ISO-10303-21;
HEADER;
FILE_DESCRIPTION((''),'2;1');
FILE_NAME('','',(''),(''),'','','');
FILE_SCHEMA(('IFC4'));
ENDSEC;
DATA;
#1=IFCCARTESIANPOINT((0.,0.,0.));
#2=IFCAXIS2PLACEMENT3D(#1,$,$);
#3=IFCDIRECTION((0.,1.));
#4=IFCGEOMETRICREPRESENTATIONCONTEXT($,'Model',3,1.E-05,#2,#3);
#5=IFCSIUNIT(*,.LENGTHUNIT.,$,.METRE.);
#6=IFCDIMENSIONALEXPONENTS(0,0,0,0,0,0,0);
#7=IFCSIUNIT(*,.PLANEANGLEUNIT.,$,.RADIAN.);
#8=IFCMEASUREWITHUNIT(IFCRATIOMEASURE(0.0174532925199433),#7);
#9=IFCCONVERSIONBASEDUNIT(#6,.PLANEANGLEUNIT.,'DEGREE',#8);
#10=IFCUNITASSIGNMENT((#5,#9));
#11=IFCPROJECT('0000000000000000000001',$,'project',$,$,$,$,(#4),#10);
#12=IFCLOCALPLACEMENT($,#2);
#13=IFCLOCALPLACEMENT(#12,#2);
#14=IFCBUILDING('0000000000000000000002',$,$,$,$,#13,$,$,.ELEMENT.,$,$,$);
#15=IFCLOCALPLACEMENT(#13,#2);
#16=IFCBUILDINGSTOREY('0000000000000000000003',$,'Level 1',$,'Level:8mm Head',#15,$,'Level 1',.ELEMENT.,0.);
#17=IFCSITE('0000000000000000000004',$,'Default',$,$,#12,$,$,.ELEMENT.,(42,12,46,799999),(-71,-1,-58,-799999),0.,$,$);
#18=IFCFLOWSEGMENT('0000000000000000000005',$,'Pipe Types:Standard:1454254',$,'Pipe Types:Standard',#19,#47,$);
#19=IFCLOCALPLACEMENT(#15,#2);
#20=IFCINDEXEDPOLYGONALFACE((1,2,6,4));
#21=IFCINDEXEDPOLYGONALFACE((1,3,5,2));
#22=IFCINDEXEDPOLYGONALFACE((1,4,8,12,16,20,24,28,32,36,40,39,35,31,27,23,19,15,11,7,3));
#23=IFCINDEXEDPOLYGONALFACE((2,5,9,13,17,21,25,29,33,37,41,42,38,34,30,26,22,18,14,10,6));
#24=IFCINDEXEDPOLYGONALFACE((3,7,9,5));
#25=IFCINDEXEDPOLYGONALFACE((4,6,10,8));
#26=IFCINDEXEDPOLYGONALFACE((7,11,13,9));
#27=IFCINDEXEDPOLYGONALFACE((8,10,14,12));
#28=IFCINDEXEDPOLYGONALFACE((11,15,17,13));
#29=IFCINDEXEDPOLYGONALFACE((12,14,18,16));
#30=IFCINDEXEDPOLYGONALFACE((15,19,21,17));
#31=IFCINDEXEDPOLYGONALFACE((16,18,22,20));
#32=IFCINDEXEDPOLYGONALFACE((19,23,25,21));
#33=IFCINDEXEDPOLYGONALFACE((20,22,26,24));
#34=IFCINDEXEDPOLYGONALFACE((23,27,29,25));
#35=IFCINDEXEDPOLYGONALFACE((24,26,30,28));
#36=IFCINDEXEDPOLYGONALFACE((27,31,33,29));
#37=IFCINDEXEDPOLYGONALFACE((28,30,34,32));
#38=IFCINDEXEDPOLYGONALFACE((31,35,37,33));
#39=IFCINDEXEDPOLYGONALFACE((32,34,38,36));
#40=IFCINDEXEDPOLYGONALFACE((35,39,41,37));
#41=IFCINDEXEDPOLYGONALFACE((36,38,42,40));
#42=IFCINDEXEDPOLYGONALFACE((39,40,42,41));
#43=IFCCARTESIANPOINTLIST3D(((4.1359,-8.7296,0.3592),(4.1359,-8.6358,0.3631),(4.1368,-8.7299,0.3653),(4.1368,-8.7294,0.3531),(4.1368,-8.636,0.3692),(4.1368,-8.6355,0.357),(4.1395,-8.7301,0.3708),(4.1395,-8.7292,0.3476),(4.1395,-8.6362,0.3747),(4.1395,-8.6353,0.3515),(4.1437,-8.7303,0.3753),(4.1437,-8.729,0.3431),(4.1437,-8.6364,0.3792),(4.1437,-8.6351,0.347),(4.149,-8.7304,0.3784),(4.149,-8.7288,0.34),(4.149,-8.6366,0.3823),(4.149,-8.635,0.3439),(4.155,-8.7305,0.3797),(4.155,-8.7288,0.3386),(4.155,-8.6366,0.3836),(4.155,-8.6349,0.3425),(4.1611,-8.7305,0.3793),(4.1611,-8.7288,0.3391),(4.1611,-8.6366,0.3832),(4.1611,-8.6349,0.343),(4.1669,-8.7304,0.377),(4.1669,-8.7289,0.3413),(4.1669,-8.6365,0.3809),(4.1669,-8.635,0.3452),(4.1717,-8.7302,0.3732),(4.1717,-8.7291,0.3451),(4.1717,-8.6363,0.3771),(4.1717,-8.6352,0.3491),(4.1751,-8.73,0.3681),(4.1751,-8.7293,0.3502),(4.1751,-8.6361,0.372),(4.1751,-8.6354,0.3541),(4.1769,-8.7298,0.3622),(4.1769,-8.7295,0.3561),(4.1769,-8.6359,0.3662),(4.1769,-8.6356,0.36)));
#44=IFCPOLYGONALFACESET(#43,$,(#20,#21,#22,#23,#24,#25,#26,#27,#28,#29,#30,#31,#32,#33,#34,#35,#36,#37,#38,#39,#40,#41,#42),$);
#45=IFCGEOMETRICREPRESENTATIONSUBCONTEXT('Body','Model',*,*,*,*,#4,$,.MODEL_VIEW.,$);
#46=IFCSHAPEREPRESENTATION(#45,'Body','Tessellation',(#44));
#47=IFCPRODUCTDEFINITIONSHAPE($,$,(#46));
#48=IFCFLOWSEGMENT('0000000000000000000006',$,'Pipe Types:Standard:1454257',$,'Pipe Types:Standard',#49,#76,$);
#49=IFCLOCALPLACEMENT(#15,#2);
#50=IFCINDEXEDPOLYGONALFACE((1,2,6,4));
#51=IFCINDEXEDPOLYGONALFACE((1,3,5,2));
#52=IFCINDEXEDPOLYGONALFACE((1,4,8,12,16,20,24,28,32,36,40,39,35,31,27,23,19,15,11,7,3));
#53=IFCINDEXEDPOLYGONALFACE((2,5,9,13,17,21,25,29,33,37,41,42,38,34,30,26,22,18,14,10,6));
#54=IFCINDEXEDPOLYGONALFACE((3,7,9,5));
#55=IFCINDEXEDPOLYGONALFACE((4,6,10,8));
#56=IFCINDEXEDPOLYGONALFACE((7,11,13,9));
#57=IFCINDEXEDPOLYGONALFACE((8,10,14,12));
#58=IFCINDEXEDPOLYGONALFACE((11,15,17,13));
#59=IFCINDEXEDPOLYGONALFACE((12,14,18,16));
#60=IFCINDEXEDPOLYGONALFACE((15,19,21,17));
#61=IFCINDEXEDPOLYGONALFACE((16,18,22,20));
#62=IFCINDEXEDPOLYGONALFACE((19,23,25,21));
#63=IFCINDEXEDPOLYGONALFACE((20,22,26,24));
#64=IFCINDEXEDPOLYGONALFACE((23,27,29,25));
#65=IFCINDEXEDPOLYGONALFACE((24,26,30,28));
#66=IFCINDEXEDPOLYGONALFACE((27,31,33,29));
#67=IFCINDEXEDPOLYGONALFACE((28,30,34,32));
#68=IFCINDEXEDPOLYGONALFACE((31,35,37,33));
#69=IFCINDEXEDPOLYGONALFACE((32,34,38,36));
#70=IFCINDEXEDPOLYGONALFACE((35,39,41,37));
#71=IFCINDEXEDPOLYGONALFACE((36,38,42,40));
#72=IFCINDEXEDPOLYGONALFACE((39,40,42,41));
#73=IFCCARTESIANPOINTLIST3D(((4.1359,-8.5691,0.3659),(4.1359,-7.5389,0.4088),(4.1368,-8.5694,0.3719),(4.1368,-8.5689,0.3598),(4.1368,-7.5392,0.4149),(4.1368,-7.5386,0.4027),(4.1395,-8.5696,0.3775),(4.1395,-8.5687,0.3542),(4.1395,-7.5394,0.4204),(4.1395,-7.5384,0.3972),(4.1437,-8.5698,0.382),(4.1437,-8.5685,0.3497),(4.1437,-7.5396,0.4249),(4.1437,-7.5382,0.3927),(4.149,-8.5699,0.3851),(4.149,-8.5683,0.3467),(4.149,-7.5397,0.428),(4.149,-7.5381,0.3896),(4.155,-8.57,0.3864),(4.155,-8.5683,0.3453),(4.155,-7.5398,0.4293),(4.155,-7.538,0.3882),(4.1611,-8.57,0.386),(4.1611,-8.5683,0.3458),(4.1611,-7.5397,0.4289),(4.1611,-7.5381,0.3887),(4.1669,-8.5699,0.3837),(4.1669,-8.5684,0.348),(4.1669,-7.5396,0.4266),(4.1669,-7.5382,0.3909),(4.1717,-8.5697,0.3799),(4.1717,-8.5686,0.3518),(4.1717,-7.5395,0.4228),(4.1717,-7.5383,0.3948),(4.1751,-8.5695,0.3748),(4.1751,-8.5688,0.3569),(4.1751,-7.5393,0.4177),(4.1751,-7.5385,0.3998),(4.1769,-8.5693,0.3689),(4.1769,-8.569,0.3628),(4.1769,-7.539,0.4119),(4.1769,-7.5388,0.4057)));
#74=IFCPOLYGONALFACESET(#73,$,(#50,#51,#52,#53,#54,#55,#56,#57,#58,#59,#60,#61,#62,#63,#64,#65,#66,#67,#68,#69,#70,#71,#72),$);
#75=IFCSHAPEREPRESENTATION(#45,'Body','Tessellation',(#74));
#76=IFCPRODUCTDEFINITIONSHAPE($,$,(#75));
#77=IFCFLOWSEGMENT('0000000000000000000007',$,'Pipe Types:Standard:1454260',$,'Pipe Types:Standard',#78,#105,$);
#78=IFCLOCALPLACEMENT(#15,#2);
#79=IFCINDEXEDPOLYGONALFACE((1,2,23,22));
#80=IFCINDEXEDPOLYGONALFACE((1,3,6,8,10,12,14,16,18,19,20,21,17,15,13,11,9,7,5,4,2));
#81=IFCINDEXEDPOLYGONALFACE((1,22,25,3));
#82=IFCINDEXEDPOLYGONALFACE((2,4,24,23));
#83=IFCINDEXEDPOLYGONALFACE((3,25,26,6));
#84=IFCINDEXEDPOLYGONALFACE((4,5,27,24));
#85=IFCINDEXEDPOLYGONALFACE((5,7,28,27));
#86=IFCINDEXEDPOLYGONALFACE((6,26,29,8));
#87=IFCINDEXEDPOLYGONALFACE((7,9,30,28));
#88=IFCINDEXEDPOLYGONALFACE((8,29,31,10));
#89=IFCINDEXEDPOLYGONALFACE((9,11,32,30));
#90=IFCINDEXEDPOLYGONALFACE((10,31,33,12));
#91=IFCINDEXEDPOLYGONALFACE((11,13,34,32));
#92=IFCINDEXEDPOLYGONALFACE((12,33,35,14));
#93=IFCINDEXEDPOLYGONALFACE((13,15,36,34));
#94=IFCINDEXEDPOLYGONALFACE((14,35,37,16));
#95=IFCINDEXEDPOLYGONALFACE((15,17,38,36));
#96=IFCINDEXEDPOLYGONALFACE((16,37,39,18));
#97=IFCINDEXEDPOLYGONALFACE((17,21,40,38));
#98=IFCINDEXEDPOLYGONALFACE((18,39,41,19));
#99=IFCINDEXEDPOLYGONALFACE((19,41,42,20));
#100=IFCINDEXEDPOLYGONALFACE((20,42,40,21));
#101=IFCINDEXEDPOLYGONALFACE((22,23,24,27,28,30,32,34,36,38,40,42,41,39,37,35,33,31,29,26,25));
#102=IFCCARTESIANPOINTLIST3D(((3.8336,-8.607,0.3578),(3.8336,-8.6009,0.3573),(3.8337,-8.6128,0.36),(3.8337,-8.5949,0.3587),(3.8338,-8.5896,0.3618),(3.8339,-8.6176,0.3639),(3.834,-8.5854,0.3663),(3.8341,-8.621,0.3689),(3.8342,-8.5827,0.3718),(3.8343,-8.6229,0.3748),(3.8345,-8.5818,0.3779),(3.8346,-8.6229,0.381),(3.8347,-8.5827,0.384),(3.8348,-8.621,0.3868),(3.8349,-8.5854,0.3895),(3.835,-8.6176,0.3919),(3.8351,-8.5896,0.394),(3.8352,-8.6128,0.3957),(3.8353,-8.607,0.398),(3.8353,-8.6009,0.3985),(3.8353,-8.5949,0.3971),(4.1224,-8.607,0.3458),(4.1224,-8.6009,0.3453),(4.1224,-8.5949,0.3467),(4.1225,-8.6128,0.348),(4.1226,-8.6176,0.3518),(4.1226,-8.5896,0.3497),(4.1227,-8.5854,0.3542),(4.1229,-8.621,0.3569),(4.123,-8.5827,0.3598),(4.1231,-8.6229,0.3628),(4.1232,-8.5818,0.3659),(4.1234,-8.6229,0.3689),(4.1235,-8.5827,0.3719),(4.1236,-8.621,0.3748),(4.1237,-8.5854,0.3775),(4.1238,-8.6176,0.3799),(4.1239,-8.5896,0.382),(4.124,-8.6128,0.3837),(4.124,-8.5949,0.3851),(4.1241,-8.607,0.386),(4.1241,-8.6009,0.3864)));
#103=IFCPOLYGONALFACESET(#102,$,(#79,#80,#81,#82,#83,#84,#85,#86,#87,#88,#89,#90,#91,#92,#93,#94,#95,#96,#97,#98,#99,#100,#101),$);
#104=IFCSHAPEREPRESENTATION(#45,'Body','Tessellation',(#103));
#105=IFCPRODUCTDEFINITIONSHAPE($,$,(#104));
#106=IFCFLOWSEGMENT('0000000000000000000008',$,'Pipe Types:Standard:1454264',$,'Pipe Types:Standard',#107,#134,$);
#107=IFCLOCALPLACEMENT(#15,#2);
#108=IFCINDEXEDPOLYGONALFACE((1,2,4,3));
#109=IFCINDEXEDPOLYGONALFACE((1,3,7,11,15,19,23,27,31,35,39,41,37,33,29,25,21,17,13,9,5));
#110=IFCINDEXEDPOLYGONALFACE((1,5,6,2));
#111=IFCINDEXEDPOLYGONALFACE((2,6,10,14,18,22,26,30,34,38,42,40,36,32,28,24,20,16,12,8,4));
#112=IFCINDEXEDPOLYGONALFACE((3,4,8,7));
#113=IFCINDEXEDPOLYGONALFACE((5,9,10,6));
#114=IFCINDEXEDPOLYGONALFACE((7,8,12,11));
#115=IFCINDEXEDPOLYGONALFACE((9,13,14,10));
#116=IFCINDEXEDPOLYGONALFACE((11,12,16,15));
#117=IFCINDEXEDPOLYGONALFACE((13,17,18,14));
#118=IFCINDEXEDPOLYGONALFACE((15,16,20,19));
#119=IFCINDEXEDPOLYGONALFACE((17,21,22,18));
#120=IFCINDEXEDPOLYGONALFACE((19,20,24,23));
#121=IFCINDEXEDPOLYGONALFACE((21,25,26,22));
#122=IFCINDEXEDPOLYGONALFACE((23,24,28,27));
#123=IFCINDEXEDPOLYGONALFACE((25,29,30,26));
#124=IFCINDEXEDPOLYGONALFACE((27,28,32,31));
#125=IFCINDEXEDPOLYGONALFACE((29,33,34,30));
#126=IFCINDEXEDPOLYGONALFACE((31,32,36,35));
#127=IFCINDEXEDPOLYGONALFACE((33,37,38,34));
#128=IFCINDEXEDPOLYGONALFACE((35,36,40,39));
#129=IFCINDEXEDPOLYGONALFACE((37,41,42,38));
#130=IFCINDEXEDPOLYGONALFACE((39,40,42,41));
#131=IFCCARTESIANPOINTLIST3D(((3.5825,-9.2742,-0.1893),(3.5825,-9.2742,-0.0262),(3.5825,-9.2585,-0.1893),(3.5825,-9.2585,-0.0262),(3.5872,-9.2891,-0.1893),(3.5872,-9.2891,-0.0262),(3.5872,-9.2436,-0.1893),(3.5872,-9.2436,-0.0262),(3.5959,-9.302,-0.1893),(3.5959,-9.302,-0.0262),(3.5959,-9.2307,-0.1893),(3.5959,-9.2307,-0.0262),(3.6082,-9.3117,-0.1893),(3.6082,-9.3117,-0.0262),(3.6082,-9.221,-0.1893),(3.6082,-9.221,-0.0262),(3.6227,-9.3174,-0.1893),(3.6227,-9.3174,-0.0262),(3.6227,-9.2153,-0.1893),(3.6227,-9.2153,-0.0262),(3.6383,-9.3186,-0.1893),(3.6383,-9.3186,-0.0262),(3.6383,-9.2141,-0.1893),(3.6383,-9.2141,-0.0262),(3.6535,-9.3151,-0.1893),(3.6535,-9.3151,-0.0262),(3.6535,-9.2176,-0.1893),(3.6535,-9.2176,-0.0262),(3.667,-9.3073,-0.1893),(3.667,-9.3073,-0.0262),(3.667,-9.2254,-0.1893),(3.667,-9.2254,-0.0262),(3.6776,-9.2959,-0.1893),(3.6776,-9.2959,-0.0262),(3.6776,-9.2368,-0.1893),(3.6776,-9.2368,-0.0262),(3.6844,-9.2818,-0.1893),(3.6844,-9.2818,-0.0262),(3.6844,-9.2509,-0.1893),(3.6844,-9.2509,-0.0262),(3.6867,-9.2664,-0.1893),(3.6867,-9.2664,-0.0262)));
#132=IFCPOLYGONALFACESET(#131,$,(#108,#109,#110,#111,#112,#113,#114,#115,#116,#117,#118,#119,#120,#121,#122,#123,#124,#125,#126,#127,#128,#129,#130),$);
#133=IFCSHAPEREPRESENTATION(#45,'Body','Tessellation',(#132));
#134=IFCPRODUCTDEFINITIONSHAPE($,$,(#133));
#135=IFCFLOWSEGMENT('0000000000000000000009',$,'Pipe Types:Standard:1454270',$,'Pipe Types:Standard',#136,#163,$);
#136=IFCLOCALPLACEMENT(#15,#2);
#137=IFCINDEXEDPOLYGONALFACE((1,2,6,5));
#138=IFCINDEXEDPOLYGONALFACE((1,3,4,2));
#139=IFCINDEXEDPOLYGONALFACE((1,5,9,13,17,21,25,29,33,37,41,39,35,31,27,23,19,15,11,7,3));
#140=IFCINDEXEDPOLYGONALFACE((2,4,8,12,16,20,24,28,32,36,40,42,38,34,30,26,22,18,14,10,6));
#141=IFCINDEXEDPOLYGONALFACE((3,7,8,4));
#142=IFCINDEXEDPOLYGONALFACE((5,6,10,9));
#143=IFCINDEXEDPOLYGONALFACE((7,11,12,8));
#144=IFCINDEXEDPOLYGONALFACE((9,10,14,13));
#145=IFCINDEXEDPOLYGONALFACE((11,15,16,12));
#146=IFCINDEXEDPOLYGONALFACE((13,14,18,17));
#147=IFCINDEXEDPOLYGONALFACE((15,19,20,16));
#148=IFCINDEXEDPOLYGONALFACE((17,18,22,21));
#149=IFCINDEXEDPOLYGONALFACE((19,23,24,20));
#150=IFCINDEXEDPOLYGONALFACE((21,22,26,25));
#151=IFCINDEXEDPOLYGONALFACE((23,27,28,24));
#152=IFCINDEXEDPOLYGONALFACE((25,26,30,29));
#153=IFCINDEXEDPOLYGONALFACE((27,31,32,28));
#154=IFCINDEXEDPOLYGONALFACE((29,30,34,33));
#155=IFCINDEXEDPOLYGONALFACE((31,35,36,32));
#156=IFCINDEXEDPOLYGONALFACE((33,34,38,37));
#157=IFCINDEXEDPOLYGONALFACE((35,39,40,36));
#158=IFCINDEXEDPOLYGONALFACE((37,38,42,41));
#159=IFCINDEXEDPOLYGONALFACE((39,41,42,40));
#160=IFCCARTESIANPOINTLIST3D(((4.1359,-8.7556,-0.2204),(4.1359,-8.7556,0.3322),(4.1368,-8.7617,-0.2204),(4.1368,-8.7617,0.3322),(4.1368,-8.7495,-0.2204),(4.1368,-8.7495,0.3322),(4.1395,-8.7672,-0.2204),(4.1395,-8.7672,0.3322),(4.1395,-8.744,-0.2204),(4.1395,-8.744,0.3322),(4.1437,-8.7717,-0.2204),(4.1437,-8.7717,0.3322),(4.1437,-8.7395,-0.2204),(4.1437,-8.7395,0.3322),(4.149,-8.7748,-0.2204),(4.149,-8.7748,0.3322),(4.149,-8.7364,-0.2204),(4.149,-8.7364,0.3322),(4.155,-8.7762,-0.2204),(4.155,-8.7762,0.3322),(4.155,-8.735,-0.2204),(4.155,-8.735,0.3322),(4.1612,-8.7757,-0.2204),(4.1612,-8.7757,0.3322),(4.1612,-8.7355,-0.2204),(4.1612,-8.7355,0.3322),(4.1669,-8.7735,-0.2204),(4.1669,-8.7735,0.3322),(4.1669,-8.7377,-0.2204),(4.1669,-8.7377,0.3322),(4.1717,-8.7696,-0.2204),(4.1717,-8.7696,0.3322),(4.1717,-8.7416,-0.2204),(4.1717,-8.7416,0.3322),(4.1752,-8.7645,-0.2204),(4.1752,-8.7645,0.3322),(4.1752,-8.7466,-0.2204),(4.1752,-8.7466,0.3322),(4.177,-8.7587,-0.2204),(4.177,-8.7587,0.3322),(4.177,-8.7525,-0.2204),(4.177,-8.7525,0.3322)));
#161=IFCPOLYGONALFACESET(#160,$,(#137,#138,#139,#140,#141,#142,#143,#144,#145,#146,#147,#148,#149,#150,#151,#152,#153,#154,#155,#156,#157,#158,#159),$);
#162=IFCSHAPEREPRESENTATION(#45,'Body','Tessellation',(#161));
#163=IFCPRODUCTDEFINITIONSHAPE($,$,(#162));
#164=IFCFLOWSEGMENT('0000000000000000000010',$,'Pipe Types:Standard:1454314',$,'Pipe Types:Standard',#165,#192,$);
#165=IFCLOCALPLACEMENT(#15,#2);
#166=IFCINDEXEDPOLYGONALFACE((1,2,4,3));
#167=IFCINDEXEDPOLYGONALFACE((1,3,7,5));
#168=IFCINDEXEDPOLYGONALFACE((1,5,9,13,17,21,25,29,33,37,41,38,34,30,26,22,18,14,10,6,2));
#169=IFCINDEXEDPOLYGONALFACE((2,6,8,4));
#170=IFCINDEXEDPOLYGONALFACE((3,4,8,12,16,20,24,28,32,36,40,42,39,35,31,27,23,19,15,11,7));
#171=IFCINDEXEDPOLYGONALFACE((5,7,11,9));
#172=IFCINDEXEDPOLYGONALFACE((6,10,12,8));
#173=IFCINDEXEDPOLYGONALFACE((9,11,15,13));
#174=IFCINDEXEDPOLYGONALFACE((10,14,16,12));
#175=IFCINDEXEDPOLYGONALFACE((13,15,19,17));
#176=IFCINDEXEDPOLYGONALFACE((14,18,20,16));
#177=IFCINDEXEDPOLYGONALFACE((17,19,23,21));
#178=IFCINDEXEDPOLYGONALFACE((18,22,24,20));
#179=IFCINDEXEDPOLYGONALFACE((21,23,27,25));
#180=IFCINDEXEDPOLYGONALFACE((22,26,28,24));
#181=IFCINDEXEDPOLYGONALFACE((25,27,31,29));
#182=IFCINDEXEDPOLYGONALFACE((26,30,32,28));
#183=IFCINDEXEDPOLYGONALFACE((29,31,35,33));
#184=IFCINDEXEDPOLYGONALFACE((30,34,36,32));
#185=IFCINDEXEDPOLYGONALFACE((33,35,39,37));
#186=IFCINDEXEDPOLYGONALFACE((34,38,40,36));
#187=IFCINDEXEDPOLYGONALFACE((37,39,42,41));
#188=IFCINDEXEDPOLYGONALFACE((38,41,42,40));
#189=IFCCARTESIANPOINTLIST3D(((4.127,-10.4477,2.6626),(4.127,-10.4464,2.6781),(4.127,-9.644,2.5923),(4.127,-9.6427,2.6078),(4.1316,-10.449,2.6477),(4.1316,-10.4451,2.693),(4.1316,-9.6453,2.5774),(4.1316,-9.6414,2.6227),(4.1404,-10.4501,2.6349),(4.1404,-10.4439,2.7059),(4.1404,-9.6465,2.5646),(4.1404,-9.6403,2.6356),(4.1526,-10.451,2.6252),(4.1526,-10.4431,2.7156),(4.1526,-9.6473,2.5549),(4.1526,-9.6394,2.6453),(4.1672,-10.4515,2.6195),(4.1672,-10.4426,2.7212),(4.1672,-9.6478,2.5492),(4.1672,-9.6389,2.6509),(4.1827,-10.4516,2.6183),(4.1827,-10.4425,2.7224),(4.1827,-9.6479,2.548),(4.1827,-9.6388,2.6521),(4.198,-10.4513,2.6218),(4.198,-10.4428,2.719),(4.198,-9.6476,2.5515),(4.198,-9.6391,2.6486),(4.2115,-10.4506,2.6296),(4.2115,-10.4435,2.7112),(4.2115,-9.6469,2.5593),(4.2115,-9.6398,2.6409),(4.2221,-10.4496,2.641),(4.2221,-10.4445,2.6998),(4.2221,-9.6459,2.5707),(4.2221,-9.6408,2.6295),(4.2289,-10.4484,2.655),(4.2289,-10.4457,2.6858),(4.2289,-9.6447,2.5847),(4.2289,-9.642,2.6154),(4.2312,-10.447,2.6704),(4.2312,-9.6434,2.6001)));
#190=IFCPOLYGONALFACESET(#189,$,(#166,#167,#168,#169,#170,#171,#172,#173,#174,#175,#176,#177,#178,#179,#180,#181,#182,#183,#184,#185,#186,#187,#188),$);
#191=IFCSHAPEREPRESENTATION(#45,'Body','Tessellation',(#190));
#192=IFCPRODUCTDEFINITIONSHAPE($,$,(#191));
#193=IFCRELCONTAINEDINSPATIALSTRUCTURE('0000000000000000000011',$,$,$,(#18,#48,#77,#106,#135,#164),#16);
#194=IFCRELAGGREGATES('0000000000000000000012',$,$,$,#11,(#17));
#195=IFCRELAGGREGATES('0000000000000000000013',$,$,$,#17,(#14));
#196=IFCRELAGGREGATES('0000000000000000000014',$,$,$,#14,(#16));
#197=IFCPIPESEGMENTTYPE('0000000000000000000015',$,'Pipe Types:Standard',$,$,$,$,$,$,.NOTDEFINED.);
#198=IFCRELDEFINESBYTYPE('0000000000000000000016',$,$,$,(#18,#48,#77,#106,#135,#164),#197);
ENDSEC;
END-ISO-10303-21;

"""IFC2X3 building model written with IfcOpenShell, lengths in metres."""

from ifc_helpers import new_model, entity, si_unit, converted_unit, direction, frame, frame_2d, origin, origin_2d_with_axis, place, context, subcontext, project, spatial, circle, extrude, type_object, element, save


model = new_model("IFC2X3")

# Units and contexts
model_context = context("Model", 3, precision=1e-05, world=origin(), true_north=direction((0.0, 1.0)))
body_context = subcontext(model_context, "Body", "Model", "MODEL_VIEW")
ifc_project = project(units=[si_unit("LENGTHUNIT", "METRE"), converted_unit("PLANEANGLEUNIT", "DEGREE", entity("IfcRatioMeasure", 0.0174532925199433), si_unit("PLANEANGLEUNIT", "RADIAN"), dimensions=[0, 0, 0, 0, 0, 0, 0])], contexts=[model_context])

# Site, building, storey
site_placement = place(None, origin())
site = spatial("IfcSite", under=ifc_project, at=site_placement, Name="Default", CompositionType="ELEMENT", RefLatitude=(42, 12, 46, 799999), RefLongitude=(-71, -1, -58, -799999), RefElevation=0.0)
building_placement = place(site_placement, origin())
building = spatial("IfcBuilding", under=site, at=building_placement, CompositionType="ELEMENT")
storey_placement = place(building_placement, origin())
storey = spatial("IfcBuildingStorey", under=building, at=storey_placement, Name="Level 1", ObjectType="Level:8mm Head", LongName="Level 1", CompositionType="ELEMENT", Elevation=0.0)

# Flow segments
pipe_segment_type = type_object("IfcPipeSegmentType", Name="Pipe Types:Standard", PredefinedType="NOTDEFINED")
flow_segment_1_placement = place(storey_placement, origin())
element("IfcFlowSegment", 1, at=flow_segment_1_placement, inside=storey, type_object=pipe_segment_type, Name="Pipe Types:Standard:1454254", ObjectType="Pipe Types:Standard", context=body_context, shape_type="SweptSolid", body=[
    extrude(circle(Radius=0.0206, at=frame_2d((0.0, 0.0), x_axis=(1.0, 0.0))), frame((4.1565, -8.7296, 0.3592), z_axis=(0.0, 0.999133, 0.041631), x_axis=(-1.0, 0.0, 0.0)), (0.0, 0.0, 1.0), 0.094),
])
flow_segment_2_placement = place(storey_placement, origin())
element("IfcFlowSegment", 2, at=flow_segment_2_placement, inside=storey, type_object=pipe_segment_type, Name="Pipe Types:Standard:1454257", ObjectType="Pipe Types:Standard", context=body_context, shape_type="SweptSolid", body=[
    extrude(circle(Radius=0.0206, at=origin_2d_with_axis()), frame((4.1565, -8.5691, 0.3659), z_axis=(0.0, 0.999133, 0.041631), x_axis=(-1.0, 0.0, 0.0)), (0.0, 0.0, 1.0), 1.0311),
])
flow_segment_3_placement = place(storey_placement, origin())
element("IfcFlowSegment", 3, at=flow_segment_3_placement, inside=storey, type_object=pipe_segment_type, Name="Pipe Types:Standard:1454260", ObjectType="Pipe Types:Standard", context=body_context, shape_type="SweptSolid", body=[
    extrude(circle(Radius=0.0206, at=origin_2d_with_axis()), frame((3.8345, -8.6024, 0.3779), z_axis=(0.999133, 0.0, -0.041631), x_axis=(0.0, 1.0, 0.0)), (0.0, 0.0, 1.0), 0.289),
])
flow_segment_4_placement = place(storey_placement, origin())
element("IfcFlowSegment", 4, at=flow_segment_4_placement, inside=storey, type_object=pipe_segment_type, Name="Pipe Types:Standard:1454264", ObjectType="Pipe Types:Standard", context=body_context, shape_type="SweptSolid", body=[
    extrude(circle(Radius=0.0524, at=frame_2d((0.0, 0.0), x_axis=(1.0, 0.0))), frame((3.6344, -9.2664, -0.1893)), (0.0, 0.0, 1.0), 0.1631),
])
flow_segment_5_placement = place(storey_placement, origin())
element("IfcFlowSegment", 5, at=flow_segment_5_placement, inside=storey, type_object=pipe_segment_type, Name="Pipe Types:Standard:1454270", ObjectType="Pipe Types:Standard", context=body_context, shape_type="SweptSolid", body=[
    extrude(circle(Radius=0.0206, at=frame_2d((0.0, 0.0), x_axis=(1.0, 0.0))), frame((4.1566, -8.7556, -0.2204), z_axis=(0.0, 0.0, 1.0), x_axis=(-1.0, 0.0, 0.0)), (0.0, 0.0, 1.0), 0.5526),
])
flow_segment_6_placement = place(storey_placement, origin())
element("IfcFlowSegment", 6, at=flow_segment_6_placement, inside=storey, type_object=pipe_segment_type, Name="Pipe Types:Standard:1454314", ObjectType="Pipe Types:Standard", context=body_context, shape_type="SweptSolid", body=[
    extrude(circle(Radius=0.0524, at=origin_2d_with_axis()), frame((4.1788, -9.6434, 2.6001), z_axis=(0.0, -0.996195, 0.087156), x_axis=(1.0, 0.0, 0.0)), (0.0, 0.0, 1.0), 0.8068),
])

save(model, "model.ifc")
